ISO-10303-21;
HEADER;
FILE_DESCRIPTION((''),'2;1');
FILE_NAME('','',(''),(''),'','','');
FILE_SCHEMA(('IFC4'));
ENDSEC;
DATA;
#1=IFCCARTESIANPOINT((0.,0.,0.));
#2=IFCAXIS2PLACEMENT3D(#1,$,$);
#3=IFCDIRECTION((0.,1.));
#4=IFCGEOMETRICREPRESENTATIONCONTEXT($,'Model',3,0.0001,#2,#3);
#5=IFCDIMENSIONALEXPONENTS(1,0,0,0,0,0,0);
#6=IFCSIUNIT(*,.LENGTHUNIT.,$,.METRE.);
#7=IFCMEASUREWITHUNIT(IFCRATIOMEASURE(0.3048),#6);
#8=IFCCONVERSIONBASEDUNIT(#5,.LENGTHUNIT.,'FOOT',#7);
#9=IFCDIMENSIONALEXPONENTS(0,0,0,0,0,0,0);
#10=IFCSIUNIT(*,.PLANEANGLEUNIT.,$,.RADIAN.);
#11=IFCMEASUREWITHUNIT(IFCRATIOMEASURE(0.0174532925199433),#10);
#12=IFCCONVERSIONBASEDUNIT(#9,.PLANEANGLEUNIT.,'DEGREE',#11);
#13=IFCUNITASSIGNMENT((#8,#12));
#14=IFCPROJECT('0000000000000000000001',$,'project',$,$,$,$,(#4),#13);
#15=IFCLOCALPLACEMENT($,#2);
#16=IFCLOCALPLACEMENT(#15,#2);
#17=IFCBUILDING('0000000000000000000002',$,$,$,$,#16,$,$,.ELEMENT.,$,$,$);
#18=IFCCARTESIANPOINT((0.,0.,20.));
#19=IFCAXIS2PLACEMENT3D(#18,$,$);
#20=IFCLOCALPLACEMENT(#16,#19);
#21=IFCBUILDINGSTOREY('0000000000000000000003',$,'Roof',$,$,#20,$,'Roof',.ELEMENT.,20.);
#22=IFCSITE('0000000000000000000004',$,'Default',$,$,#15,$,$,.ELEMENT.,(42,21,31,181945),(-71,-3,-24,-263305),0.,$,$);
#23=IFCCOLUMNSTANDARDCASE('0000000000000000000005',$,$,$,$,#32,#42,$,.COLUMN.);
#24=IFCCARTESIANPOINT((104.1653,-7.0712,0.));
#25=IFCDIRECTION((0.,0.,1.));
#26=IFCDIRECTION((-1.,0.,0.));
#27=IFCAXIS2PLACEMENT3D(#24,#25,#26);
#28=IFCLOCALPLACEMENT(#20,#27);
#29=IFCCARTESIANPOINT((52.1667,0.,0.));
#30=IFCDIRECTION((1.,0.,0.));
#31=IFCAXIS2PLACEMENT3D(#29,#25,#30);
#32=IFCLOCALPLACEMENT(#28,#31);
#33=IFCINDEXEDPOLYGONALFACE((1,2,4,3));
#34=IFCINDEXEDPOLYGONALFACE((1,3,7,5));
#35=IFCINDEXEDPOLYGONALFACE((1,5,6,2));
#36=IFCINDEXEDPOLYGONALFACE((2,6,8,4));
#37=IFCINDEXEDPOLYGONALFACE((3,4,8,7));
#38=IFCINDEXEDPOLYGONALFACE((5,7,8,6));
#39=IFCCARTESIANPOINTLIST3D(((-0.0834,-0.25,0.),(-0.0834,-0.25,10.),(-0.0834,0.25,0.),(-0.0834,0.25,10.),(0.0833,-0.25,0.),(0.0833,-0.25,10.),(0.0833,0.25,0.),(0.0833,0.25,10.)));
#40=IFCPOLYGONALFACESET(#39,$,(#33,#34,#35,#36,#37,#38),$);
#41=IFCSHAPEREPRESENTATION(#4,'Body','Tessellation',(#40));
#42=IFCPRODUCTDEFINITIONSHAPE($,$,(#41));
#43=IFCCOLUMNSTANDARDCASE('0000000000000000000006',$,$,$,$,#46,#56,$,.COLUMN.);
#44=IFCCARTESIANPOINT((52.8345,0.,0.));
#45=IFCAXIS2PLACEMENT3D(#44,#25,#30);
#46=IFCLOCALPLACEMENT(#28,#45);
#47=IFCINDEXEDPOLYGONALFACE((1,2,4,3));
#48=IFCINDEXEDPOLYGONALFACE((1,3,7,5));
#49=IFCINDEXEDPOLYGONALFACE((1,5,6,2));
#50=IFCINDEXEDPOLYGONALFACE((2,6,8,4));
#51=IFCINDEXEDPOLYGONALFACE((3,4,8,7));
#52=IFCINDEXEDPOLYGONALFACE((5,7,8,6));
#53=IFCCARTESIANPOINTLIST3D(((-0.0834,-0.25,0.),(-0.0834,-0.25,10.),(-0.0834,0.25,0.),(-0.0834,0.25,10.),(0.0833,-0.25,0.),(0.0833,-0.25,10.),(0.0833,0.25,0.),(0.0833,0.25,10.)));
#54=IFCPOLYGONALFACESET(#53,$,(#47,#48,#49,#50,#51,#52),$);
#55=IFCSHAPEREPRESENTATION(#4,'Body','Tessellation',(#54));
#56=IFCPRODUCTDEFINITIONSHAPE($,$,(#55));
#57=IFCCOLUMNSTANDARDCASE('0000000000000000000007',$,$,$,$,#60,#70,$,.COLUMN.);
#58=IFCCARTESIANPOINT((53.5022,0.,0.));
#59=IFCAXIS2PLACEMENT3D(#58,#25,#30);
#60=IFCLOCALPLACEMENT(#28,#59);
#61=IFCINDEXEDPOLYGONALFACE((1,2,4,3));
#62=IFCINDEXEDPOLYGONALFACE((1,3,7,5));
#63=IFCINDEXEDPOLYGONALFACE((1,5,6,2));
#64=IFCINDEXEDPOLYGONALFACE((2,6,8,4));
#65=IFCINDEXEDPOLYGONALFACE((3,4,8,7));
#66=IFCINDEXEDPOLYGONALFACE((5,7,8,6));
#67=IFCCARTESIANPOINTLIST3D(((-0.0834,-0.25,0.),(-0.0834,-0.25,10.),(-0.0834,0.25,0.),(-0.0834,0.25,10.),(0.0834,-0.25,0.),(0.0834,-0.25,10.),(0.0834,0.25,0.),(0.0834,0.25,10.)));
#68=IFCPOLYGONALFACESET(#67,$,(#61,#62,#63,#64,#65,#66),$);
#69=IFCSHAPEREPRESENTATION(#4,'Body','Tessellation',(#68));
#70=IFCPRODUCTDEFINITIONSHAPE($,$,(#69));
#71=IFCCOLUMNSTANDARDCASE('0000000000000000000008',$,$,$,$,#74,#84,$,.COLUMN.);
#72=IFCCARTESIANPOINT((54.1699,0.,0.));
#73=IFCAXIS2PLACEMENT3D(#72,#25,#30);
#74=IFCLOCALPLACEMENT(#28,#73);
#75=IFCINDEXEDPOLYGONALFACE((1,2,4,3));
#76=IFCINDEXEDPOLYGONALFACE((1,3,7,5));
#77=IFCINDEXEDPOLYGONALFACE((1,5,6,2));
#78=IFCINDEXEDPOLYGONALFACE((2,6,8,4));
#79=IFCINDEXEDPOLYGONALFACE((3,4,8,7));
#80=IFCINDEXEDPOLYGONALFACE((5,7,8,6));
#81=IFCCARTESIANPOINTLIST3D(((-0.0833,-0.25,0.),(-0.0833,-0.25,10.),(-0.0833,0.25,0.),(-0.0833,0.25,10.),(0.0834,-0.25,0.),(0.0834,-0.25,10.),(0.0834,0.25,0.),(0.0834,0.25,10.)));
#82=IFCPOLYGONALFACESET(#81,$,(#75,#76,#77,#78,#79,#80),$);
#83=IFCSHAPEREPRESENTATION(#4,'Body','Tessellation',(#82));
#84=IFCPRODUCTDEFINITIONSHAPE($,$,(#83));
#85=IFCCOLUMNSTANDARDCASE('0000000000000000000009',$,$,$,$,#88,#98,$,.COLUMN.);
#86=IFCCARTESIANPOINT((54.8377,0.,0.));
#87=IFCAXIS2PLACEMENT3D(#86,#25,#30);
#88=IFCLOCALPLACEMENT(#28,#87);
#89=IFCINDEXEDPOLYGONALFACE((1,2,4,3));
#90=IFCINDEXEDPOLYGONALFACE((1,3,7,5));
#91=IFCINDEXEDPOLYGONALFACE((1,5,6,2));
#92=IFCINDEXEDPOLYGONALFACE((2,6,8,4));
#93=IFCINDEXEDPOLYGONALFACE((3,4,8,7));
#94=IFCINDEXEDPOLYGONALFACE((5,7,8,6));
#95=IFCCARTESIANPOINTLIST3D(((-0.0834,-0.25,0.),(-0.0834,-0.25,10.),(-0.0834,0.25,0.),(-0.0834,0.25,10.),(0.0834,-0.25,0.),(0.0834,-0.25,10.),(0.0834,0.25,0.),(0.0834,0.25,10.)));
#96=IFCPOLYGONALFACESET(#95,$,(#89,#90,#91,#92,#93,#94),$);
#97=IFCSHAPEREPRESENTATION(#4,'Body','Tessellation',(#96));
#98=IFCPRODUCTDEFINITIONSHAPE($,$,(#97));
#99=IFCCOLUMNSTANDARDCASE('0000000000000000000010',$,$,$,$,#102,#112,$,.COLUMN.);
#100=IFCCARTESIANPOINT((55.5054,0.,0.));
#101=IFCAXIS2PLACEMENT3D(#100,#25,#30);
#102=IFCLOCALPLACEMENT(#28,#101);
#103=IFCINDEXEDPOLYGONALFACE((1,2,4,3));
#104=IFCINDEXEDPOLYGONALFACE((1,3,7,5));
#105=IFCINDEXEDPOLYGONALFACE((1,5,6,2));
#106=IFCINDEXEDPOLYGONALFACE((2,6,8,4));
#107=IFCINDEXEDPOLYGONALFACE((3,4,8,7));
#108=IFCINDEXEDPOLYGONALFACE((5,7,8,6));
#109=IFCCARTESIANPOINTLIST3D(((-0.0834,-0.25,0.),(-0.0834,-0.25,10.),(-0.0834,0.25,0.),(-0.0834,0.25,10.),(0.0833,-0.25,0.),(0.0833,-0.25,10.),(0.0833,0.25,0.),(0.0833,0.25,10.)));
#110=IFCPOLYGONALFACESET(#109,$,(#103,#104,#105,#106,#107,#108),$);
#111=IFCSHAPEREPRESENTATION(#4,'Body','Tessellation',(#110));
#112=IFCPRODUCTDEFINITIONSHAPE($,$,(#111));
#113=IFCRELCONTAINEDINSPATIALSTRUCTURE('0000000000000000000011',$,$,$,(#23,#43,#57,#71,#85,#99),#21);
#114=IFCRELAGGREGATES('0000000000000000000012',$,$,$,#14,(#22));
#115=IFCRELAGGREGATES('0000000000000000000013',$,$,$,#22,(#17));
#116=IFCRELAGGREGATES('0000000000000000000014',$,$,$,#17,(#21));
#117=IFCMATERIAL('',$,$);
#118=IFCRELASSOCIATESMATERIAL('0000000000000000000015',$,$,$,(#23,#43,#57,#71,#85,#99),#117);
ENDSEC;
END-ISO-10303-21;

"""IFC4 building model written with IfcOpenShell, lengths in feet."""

from ifc_helpers import new_model, entity, si_unit, converted_unit, direction, frame, origin, place, context, project, spatial, rectangle, extrude, material, element, save


model = new_model("IFC4")

# Units and contexts
model_context = context("Model", 3, precision=0.0001, world=origin(), true_north=direction((0.0, 1.0)))
ifc_project = project(units=[converted_unit("LENGTHUNIT", "FOOT", entity("IfcRatioMeasure", 0.3048), si_unit("LENGTHUNIT", "METRE"), dimensions=[1, 0, 0, 0, 0, 0, 0]), converted_unit("PLANEANGLEUNIT", "DEGREE", entity("IfcRatioMeasure", 0.0174532925199433), si_unit("PLANEANGLEUNIT", "RADIAN"), dimensions=[0, 0, 0, 0, 0, 0, 0])], contexts=[model_context])

# Site, building, storey
site_placement = place(None, origin())
site = spatial("IfcSite", under=ifc_project, at=site_placement, Name="Default", CompositionType="ELEMENT", RefLatitude=(42, 21, 31, 181945), RefLongitude=(-71, -3, -24, -263305), RefElevation=0.0)
building_placement = place(site_placement, origin())
building = spatial("IfcBuilding", under=site, at=building_placement, CompositionType="ELEMENT")
storey_placement = place(building_placement, frame((0.0, 0.0, 20.0)))
storey = spatial("IfcBuildingStorey", under=building, at=storey_placement, Name="Roof", LongName="Roof", CompositionType="ELEMENT", Elevation=20.0)

# Columns
ifc_material_1 = material(Name="")
placement_1 = place(storey_placement, frame((104.1653, -7.0712, 0.0), z_axis=(0.0, 0.0, 1.0), x_axis=(-1.0, 0.0, 0.0)))
for number, where, z_axis, x_axis in (
    (1, (52.1667, 0.0, 0.0), (0.0, 0.0, 1.0), (1.0, 0.0, 0.0)),
    (2, (52.8345, 0.0, 0.0), (0.0, 0.0, 1.0), (1.0, 0.0, 0.0)),
    (3, (53.5022, 0.0, 0.0), (0.0, 0.0, 1.0), (1.0, 0.0, 0.0)),
    (4, (54.1699, 0.0, 0.0), (0.0, 0.0, 1.0), (1.0, 0.0, 0.0)),
    (5, (54.8377, 0.0, 0.0), (0.0, 0.0, 1.0), (1.0, 0.0, 0.0)),
    (6, (55.5054, 0.0, 0.0), (0.0, 0.0, 1.0), (1.0, 0.0, 0.0)),
):
    element("IfcColumnStandardCase", number, at=place(placement_1, frame(where, z_axis=z_axis, x_axis=x_axis)), inside=storey, material=ifc_material_1, PredefinedType="COLUMN", context=model_context, shape_type="SweptSolid", body=[
        extrude(rectangle(XDim=0.1667, YDim=0.5), origin(), (0.0, 0.0, 1.0), 10.0),
    ])

save(model, "model.ifc")
